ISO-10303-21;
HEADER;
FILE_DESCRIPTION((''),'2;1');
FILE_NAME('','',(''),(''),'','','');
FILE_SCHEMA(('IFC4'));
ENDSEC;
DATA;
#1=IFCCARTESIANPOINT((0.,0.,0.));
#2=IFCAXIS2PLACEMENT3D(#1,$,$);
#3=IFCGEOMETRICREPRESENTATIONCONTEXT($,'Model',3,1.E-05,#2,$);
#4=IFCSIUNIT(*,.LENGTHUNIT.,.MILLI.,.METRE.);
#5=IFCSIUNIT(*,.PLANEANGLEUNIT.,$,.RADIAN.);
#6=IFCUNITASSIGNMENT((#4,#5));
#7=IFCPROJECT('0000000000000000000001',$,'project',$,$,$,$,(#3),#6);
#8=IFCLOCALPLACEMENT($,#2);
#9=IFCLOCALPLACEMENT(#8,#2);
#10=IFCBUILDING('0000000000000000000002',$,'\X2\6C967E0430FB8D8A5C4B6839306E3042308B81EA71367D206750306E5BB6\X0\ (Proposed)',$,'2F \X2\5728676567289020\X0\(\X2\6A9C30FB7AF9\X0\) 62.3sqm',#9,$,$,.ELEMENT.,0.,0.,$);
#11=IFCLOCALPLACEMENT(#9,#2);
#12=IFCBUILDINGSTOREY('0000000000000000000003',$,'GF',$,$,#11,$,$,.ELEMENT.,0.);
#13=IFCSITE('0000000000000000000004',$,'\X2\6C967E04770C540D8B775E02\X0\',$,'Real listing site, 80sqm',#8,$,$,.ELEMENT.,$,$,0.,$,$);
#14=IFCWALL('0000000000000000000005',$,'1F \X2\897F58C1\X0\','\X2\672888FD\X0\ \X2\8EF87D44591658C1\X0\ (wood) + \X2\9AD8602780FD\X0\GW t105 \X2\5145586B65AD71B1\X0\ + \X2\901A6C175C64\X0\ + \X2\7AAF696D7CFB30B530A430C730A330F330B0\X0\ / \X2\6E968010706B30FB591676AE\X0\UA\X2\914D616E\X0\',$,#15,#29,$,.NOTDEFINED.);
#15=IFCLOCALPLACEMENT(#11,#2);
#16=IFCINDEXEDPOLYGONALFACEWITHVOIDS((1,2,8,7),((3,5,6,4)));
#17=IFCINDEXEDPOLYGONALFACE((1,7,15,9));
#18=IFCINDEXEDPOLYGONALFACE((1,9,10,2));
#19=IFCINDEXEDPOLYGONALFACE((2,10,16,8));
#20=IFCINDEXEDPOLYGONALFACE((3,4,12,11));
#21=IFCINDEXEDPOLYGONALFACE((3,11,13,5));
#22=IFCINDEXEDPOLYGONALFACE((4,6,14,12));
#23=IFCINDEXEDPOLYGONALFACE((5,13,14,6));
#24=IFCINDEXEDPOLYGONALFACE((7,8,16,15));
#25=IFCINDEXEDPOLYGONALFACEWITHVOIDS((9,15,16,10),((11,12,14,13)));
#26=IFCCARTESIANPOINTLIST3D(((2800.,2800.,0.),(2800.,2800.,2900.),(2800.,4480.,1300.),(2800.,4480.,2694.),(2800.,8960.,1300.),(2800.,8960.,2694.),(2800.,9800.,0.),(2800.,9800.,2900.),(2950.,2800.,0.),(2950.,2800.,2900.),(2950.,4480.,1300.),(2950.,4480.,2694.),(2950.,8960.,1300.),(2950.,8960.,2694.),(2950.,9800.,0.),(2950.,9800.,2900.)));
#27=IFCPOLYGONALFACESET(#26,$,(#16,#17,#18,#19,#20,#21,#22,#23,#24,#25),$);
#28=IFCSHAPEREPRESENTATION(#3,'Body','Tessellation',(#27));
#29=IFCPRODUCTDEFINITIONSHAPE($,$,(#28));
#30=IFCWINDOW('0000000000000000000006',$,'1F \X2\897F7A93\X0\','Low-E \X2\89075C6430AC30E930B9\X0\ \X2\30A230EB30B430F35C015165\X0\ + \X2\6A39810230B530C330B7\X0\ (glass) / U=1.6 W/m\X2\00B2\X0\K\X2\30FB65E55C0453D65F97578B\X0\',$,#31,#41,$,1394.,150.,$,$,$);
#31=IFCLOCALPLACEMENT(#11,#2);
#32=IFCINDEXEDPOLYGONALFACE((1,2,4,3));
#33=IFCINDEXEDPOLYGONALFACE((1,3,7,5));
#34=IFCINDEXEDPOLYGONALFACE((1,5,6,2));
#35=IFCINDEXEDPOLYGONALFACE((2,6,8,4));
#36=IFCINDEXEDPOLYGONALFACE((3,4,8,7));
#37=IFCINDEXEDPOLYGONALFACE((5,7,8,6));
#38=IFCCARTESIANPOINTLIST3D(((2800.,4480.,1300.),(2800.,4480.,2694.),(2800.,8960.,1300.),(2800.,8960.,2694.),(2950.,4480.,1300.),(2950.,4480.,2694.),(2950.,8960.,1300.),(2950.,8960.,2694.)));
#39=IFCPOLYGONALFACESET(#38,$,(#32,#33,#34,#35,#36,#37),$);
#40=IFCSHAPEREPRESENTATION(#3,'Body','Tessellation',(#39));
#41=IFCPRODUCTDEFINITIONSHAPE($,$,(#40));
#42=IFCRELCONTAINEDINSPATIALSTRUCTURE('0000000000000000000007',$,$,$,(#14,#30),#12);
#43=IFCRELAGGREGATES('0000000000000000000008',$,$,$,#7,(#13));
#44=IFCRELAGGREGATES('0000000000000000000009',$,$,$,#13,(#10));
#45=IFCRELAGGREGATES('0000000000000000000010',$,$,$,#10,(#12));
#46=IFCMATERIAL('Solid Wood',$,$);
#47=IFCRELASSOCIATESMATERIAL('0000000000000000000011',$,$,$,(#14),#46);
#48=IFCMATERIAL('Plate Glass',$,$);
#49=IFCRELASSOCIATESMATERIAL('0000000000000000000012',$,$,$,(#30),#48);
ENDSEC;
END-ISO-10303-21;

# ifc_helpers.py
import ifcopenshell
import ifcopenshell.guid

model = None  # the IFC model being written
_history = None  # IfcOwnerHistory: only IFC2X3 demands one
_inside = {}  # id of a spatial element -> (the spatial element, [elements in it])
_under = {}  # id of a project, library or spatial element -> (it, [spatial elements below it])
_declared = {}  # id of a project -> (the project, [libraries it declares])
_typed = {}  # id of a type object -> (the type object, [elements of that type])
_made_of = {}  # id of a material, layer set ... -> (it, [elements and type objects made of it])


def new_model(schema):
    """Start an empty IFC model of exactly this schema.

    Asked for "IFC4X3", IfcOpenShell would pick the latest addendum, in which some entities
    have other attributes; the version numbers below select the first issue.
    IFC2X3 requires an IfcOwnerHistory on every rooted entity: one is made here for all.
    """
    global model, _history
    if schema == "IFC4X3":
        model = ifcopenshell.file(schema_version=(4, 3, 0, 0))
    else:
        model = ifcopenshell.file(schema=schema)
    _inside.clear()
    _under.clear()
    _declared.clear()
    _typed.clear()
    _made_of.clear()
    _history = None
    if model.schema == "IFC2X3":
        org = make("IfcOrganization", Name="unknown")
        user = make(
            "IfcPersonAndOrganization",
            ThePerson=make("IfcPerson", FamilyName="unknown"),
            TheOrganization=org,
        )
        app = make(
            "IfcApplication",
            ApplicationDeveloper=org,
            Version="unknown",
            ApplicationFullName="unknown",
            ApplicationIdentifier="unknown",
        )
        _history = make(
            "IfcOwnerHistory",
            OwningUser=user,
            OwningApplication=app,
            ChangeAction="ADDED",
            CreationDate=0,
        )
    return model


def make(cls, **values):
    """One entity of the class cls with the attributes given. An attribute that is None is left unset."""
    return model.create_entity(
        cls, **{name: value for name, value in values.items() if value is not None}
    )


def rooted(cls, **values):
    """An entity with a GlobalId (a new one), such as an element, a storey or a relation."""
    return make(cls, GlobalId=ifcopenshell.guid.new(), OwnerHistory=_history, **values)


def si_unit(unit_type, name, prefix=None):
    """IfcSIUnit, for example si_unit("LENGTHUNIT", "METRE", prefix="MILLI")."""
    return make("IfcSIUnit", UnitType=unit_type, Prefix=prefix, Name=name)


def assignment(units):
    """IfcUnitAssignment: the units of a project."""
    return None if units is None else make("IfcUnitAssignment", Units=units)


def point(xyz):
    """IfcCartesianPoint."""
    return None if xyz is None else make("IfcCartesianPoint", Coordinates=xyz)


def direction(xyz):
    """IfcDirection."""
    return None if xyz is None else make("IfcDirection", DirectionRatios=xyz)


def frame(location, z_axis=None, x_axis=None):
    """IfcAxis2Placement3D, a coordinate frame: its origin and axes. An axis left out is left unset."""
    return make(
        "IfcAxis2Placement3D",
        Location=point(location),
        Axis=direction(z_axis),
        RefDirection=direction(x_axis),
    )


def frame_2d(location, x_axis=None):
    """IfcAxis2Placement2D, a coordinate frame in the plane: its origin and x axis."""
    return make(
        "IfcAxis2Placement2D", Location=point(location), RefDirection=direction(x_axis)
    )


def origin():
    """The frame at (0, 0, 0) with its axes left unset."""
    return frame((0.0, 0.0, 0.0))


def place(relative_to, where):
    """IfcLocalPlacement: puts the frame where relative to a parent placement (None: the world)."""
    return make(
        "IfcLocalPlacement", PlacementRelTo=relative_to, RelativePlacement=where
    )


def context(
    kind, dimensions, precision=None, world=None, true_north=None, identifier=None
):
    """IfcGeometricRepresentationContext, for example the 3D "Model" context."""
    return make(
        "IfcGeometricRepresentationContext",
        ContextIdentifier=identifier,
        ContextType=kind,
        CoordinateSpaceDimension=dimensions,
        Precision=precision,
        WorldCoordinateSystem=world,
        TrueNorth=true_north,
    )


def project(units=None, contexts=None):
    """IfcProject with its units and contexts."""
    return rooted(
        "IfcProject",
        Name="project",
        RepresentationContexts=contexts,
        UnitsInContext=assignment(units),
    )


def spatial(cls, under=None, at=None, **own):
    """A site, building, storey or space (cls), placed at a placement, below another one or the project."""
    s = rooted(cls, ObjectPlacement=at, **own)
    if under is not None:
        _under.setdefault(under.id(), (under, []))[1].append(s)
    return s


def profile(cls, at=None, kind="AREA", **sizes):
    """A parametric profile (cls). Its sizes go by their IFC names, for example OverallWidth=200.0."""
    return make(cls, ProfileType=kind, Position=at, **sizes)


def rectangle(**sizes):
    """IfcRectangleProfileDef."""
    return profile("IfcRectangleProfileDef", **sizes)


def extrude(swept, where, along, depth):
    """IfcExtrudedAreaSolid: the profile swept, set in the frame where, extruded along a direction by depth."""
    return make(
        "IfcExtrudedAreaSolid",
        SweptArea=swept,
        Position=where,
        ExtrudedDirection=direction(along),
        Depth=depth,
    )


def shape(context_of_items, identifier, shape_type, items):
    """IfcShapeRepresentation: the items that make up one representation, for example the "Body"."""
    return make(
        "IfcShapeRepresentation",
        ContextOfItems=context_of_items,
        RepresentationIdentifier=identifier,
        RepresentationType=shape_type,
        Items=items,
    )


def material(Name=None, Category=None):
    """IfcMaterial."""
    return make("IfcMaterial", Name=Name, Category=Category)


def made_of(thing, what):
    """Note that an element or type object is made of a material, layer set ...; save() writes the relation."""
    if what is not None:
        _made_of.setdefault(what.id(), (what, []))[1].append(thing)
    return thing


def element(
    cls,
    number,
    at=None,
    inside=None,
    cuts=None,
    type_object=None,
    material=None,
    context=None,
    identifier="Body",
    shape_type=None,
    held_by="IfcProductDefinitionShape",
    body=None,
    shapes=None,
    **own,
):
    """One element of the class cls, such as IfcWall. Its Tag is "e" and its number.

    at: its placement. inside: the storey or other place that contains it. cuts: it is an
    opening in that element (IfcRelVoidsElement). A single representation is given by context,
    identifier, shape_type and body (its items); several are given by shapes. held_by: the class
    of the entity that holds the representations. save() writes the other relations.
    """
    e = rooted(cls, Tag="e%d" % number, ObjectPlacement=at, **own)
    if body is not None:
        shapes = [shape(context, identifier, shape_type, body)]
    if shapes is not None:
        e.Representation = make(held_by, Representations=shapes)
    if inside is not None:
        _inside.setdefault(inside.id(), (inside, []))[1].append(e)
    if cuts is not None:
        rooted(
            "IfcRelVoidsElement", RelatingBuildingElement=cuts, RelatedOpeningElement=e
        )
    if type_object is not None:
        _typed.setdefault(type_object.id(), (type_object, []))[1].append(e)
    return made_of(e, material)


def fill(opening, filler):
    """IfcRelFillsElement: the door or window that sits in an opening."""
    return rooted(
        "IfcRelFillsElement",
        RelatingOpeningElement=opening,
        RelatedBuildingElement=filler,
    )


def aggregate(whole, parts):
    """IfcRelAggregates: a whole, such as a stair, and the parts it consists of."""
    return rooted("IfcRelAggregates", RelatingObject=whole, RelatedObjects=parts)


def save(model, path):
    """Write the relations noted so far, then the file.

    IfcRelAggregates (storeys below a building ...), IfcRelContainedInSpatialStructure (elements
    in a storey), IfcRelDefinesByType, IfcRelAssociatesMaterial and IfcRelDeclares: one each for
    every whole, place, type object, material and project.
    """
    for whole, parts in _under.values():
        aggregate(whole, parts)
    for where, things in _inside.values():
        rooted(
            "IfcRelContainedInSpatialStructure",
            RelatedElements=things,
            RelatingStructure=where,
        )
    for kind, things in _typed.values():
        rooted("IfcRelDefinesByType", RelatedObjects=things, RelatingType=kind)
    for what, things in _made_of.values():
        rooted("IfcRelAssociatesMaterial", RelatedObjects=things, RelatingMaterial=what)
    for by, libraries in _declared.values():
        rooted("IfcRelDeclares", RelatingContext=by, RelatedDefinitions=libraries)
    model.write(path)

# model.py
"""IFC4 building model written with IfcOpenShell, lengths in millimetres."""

from ifc_helpers import new_model, si_unit, frame, frame_2d, origin, place, context, project, spatial, rectangle, extrude, material, element, fill, save


model = new_model("IFC4")

# Units and contexts
model_context = context("Model", 3, precision=1e-05, world=origin())
ifc_project = project(units=[si_unit("LENGTHUNIT", "METRE", prefix="MILLI"), si_unit("PLANEANGLEUNIT", "RADIAN")], contexts=[model_context])

# Site, building, storey
site_placement = place(None, origin())
site = spatial("IfcSite", under=ifc_project, at=site_placement, Name="沖縄県名護市", ObjectType="Real listing site, 80sqm", CompositionType="ELEMENT", RefElevation=0.0)
building_placement = place(site_placement, origin())
building = spatial("IfcBuilding", under=site, at=building_placement, Name="沖縄・越屋根のある自然素材の家 (Proposed)", ObjectType="2F 在来木造(檜・竹) 62.3sqm", CompositionType="ELEMENT", ElevationOfRefHeight=0.0, ElevationOfTerrain=0.0)
storey_placement = place(building_placement, origin())
storey = spatial("IfcBuildingStorey", under=building, at=storey_placement, Name="GF", CompositionType="ELEMENT", Elevation=0.0)

# Shared definitions
ifc_material_1 = material(Name="Solid Wood")

# Shared definitions
ifc_material_2 = material(Name="Plate Glass")

# Wall, opening, window
wall_1_placement = place(storey_placement, frame((1400.0, 1400.0, 0.0)))
wall_1 = element("IfcWall", 1, at=wall_1_placement, inside=storey, material=ifc_material_1, Name="1F 西壁", Description="木製 軸組外壁 (wood) + 高性能GW t105 充填断熱 + 通気層 + 窯業系サイディング / 準耐火・外皮UA配慮", PredefinedType="NOTDEFINED", context=model_context, shape_type="SweptSolid", body=[
    extrude(rectangle(XDim=150.0, YDim=7000.0, at=frame_2d((75.0, 3500.0))), frame((1400.0, 1400.0, 0.0)), (0.0, 0.0, 1.0), 2900.0),
])
opening_1_placement = place(storey_placement, frame((1400.0, 2240.0, 650.0)))
opening_1 = element("IfcOpeningElement", 2, at=opening_1_placement, cuts=wall_1, PredefinedType="NOTDEFINED", context=model_context, shape_type="SweptSolid", body=[
    extrude(rectangle(XDim=150.0, YDim=4480.0, at=frame_2d((75.0, 2240.0))), frame((1400.0, 2240.0, 650.0)), (0.0, 0.0, 1.0), 1394.0),
])
window_1_placement = place(storey_placement, frame((1400.0, 2240.0, 650.0)))
window_1 = element("IfcWindow", 3, at=window_1_placement, inside=storey, material=ifc_material_2, Name="1F 西窓", Description="Low-E 複層ガラス アルゴン封入 + 樹脂サッシ (glass) / U=1.6 W/m²K・日射取得型", OverallHeight=1394.0, OverallWidth=150.0, context=model_context, shape_type="SweptSolid", body=[
    extrude(rectangle(XDim=150.0, YDim=4480.0, at=frame_2d((75.0, 2240.0))), frame((1400.0, 2240.0, 650.0)), (0.0, 0.0, 1.0), 1394.0),
])
fill(opening_1, window_1)

save(model, "model.ifc")
